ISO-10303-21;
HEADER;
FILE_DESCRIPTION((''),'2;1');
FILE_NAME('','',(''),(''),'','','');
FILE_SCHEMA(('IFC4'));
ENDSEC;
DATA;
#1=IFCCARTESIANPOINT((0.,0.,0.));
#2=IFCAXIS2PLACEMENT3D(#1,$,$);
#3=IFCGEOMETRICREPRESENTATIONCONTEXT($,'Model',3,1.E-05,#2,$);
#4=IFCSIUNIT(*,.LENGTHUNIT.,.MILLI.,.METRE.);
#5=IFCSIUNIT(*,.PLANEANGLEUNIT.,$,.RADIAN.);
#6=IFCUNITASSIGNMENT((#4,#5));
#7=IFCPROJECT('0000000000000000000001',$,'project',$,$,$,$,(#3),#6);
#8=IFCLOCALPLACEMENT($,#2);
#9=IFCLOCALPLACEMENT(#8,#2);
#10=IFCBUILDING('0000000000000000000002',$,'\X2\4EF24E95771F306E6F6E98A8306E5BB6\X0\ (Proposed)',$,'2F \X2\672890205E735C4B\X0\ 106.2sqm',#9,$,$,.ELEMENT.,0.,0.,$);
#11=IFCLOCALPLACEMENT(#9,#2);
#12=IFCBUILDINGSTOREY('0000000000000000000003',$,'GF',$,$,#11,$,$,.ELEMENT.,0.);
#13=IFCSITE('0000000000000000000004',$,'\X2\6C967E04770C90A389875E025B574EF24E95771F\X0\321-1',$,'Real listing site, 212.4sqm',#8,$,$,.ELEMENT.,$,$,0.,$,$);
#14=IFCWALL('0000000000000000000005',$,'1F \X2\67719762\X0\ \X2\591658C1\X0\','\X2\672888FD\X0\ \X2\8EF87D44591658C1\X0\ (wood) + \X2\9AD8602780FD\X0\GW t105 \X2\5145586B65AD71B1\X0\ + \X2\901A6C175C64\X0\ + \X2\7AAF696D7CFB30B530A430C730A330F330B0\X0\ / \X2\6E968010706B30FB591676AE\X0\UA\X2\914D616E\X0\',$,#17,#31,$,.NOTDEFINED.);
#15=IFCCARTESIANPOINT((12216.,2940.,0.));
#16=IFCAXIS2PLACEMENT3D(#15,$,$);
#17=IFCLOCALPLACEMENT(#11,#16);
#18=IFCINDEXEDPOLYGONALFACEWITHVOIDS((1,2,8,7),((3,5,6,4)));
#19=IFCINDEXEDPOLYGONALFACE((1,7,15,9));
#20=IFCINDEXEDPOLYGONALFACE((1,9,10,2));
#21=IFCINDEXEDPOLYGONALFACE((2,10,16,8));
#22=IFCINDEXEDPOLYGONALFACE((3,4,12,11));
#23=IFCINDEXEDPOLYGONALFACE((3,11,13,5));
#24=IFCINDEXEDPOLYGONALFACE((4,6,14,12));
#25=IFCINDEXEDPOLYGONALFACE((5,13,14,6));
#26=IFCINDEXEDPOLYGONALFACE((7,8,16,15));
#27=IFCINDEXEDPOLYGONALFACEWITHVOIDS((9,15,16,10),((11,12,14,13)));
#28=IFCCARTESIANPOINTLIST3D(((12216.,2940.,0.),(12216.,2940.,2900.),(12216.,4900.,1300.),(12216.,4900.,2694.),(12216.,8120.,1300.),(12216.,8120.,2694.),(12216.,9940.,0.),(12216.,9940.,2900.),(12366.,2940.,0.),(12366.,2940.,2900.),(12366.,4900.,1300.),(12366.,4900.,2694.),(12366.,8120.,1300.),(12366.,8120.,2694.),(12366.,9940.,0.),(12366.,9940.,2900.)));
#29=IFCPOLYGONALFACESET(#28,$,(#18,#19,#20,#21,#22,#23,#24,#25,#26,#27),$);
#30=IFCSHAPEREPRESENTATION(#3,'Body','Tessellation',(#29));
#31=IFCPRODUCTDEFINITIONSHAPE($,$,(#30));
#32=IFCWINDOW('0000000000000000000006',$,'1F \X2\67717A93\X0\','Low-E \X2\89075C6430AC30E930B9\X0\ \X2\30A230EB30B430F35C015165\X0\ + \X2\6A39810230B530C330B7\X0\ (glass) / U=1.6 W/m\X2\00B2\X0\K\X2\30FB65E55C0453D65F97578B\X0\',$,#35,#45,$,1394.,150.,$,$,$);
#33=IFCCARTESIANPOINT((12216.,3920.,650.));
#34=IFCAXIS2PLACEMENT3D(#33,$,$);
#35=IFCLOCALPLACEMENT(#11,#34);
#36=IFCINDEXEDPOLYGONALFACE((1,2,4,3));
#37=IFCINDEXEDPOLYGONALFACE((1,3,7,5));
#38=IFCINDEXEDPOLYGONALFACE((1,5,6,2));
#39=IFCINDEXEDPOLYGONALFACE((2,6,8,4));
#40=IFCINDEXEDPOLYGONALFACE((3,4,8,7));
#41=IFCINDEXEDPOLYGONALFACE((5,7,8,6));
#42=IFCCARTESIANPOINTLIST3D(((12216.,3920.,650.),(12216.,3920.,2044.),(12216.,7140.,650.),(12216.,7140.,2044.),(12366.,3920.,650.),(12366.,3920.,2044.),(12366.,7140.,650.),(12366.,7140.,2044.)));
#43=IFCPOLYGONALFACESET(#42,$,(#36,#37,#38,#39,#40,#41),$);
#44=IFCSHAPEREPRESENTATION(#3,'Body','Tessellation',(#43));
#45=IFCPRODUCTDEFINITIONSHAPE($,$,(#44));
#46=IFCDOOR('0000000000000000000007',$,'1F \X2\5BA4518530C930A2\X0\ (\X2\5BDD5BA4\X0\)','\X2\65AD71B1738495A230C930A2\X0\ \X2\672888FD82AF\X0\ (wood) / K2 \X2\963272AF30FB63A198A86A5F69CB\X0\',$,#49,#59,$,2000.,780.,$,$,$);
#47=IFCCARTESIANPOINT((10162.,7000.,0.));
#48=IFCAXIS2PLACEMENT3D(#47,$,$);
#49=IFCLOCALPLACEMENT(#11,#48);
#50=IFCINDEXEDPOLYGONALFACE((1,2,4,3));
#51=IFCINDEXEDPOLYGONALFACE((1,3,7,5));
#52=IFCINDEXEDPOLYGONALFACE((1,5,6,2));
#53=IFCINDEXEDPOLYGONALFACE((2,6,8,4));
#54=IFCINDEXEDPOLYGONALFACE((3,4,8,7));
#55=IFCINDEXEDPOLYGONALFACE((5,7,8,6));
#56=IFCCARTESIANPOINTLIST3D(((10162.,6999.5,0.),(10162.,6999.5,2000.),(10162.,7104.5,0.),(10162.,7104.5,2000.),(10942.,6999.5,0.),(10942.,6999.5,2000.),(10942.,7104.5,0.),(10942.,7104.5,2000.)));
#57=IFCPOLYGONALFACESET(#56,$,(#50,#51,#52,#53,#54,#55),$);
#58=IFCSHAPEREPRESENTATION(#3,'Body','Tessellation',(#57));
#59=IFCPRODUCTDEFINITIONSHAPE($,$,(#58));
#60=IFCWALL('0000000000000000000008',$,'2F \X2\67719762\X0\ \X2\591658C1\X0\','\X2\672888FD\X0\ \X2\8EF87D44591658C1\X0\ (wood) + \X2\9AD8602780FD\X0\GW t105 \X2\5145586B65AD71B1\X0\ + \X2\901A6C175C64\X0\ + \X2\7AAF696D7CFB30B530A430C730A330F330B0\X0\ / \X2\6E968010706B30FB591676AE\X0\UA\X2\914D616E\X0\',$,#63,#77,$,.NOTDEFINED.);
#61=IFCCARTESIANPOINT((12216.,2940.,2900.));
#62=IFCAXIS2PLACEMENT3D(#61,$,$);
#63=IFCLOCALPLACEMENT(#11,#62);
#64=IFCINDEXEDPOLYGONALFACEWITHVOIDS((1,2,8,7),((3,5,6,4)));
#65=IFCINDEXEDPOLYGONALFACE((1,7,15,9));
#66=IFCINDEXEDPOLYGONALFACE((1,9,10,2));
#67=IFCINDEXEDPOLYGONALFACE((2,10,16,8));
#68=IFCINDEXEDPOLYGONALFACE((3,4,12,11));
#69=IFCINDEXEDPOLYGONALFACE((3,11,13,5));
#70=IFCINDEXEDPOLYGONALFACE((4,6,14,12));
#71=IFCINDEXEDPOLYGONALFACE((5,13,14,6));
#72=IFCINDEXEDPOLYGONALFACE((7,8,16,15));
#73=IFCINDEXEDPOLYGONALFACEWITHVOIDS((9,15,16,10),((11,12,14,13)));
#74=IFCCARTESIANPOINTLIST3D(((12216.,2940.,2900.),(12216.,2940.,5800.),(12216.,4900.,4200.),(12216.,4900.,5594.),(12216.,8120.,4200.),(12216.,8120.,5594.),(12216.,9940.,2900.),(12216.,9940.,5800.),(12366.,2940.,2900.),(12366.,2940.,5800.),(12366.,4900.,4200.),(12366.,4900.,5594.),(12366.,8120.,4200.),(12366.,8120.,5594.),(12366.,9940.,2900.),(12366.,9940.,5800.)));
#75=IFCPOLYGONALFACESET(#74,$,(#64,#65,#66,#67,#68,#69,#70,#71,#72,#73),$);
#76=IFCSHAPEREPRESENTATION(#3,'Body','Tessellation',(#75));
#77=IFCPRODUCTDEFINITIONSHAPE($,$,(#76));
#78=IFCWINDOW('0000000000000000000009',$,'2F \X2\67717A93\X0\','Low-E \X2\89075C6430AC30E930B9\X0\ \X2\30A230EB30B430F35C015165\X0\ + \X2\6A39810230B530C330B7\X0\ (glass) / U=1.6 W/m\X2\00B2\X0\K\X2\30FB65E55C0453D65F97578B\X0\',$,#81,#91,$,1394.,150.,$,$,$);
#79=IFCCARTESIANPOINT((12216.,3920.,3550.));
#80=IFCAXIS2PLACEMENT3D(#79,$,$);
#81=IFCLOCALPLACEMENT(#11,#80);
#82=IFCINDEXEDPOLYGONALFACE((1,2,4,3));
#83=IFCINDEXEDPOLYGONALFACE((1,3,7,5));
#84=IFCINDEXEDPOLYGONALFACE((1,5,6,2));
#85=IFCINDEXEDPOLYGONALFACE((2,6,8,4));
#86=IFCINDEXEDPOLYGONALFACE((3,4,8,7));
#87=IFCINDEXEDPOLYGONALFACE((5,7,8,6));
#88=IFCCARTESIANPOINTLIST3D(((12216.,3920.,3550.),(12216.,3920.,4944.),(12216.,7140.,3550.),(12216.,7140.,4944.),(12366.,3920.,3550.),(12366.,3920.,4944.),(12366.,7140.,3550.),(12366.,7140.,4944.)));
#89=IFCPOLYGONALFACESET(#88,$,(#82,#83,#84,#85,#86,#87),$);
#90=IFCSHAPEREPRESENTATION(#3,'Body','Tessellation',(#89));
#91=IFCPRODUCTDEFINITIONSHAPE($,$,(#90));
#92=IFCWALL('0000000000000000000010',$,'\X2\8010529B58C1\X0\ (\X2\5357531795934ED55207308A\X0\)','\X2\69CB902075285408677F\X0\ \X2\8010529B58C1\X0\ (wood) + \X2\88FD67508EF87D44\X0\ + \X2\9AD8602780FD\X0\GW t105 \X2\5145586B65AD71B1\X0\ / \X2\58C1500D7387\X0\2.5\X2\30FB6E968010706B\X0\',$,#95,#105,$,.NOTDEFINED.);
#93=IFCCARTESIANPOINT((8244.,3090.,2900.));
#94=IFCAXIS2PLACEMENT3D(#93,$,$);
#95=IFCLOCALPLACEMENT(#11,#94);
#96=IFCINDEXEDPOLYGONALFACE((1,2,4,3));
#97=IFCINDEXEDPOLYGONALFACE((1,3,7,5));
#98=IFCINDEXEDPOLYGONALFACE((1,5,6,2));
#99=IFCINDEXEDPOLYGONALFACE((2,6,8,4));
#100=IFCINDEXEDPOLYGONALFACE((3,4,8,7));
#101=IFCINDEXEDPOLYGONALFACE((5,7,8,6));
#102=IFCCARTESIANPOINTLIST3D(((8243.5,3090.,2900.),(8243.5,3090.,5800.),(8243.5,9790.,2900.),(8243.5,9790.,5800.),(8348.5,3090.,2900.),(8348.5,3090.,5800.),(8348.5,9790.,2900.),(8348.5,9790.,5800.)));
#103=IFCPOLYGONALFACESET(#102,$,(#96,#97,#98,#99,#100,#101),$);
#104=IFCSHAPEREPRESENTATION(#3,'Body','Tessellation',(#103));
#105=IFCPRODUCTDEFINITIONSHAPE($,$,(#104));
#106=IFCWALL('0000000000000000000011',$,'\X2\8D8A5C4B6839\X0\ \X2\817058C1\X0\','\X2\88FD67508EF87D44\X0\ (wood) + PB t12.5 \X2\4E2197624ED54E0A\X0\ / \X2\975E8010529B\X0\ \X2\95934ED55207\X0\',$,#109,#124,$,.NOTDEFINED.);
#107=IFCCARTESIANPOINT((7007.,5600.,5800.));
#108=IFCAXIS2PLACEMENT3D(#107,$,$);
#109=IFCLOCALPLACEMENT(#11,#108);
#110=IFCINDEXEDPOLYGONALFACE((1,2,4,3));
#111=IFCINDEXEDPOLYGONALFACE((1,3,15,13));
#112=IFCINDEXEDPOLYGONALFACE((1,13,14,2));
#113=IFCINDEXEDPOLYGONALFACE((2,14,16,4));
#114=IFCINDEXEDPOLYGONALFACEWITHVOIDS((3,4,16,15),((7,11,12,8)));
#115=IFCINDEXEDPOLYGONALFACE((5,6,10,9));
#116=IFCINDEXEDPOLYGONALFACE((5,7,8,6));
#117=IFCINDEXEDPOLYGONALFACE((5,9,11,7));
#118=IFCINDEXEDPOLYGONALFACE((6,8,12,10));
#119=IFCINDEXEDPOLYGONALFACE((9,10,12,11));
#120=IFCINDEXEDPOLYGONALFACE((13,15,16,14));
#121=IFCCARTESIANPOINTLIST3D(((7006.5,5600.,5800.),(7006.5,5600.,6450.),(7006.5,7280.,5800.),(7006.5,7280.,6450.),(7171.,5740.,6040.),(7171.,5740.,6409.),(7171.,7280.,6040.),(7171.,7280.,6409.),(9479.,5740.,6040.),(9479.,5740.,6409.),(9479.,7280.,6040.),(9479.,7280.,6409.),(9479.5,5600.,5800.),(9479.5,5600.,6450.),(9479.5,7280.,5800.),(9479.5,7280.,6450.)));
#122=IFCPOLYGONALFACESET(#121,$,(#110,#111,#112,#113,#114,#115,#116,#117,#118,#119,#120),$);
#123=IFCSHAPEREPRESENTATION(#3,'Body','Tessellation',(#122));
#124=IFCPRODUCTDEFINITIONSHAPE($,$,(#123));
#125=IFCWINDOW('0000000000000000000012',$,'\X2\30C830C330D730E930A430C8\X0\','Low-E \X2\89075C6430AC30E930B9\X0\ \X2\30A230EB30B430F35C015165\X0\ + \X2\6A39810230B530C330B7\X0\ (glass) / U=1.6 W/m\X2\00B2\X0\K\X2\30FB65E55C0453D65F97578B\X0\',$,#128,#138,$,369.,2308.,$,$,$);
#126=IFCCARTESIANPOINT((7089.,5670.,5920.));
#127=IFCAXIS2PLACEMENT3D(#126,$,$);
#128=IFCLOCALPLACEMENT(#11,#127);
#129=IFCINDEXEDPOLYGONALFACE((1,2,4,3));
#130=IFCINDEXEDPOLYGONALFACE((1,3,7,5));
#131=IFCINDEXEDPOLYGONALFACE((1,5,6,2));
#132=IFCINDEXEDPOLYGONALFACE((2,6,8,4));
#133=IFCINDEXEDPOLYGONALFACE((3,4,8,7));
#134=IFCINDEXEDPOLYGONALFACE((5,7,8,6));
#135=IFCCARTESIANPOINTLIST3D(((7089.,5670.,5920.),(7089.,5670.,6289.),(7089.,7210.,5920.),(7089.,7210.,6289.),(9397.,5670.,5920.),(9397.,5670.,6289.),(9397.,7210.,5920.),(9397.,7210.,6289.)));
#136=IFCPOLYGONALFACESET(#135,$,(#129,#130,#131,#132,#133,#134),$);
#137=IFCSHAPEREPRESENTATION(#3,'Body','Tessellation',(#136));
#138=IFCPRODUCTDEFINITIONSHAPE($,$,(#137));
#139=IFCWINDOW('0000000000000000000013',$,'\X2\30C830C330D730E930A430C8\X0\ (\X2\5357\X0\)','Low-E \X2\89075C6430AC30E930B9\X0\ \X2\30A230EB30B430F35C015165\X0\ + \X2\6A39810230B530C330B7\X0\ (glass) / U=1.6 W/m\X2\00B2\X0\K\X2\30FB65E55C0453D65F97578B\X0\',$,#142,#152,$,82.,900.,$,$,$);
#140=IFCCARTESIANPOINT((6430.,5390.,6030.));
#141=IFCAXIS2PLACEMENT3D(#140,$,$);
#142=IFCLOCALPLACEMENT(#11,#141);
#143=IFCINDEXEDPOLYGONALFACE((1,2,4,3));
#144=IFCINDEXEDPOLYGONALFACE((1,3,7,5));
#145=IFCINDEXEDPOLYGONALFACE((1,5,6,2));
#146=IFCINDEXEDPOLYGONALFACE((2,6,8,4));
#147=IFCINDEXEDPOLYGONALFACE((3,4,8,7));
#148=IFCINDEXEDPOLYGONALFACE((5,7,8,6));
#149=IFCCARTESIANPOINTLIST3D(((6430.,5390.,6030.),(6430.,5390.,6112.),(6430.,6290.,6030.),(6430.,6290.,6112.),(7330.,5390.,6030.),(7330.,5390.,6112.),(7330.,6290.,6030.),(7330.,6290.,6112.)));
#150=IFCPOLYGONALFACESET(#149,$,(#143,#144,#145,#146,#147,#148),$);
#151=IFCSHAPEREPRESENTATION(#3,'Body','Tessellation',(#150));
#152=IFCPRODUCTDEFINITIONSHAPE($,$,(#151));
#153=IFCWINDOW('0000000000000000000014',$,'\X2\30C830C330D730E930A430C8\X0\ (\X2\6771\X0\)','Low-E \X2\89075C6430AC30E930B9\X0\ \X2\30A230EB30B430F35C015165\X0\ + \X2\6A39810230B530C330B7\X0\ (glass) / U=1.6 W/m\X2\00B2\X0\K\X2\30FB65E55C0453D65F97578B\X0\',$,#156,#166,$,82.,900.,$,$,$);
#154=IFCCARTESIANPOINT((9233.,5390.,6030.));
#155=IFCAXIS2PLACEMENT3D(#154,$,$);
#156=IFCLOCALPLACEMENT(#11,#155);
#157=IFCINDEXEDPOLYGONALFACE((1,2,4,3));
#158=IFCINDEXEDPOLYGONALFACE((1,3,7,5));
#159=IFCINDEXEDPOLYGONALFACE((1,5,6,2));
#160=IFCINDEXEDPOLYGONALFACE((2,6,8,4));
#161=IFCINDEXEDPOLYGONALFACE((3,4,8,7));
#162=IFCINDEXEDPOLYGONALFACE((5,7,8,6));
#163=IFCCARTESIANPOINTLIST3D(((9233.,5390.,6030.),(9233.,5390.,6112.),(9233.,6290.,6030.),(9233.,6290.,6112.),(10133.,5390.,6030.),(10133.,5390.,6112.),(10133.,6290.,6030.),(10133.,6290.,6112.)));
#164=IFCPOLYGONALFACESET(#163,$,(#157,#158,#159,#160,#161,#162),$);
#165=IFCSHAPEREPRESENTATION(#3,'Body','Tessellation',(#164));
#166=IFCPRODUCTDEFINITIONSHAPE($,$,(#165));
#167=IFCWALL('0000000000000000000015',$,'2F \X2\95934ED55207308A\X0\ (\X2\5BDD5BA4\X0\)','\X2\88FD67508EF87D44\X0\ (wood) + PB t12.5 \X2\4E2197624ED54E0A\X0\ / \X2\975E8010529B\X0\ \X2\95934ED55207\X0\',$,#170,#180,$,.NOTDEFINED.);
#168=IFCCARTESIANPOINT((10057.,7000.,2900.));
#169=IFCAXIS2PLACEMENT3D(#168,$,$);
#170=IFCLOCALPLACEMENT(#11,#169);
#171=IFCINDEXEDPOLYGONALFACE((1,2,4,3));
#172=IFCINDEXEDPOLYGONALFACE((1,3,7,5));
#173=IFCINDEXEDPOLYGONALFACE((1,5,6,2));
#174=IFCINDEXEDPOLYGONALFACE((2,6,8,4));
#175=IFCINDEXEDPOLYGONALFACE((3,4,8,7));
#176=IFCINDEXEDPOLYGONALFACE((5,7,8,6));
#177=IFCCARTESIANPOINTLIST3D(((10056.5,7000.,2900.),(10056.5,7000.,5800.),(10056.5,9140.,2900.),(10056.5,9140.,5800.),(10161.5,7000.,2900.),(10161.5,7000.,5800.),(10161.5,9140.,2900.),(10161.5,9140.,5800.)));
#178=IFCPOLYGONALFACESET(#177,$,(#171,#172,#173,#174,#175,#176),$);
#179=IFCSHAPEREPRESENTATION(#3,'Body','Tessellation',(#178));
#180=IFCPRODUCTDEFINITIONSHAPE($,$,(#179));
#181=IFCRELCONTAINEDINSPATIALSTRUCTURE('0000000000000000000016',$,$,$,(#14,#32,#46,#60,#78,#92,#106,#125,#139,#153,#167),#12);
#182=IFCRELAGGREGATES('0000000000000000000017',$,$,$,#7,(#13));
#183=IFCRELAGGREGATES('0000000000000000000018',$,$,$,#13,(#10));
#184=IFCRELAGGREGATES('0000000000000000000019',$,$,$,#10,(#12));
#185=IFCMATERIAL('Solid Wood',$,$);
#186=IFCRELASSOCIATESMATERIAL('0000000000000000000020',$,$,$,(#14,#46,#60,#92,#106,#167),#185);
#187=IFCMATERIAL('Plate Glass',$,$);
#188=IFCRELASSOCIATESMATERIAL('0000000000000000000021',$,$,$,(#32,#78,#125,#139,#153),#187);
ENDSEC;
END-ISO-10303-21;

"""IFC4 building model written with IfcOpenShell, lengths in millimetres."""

from ifc_helpers import new_model, si_unit, frame, frame_2d, origin, place, context, project, spatial, rectangle, extrude, material, element, fill, save


model = new_model("IFC4")

# Units and contexts
model_context = context("Model", 3, precision=1e-05, world=origin())
ifc_project = project(units=[si_unit("LENGTHUNIT", "METRE", prefix="MILLI"), si_unit("PLANEANGLEUNIT", "RADIAN")], contexts=[model_context])

# Site, building, storey
site_placement = place(None, origin())
site = spatial("IfcSite", under=ifc_project, at=site_placement, Name="沖縄県那覇市字仲井真321-1", ObjectType="Real listing site, 212.4sqm", CompositionType="ELEMENT", RefElevation=0.0)
building_placement = place(site_placement, origin())
building = spatial("IfcBuilding", under=site, at=building_placement, Name="仲井真の潮風の家 (Proposed)", ObjectType="2F 木造平屋 106.2sqm", CompositionType="ELEMENT", ElevationOfRefHeight=0.0, ElevationOfTerrain=0.0)
storey_placement = place(building_placement, origin())
storey = spatial("IfcBuildingStorey", under=building, at=storey_placement, Name="GF", CompositionType="ELEMENT", Elevation=0.0)

# Wall, opening, window
ifc_material_1 = material(Name="Solid Wood")
wall_1_placement = place(storey_placement, frame((12216.0, 2940.0, 0.0)))
wall_1 = element("IfcWall", 1, at=wall_1_placement, inside=storey, material=ifc_material_1, Name="1F 東面 外壁", Description="木製 軸組外壁 (wood) + 高性能GW t105 充填断熱 + 通気層 + 窯業系サイディング / 準耐火・外皮UA配慮", PredefinedType="NOTDEFINED", context=model_context, shape_type="SweptSolid", body=[
    extrude(rectangle(XDim=150.0, YDim=7000.0, at=frame_2d((75.0, 3500.0))), frame((12216.0, 2940.0, 0.0)), (0.0, 0.0, 1.0), 2900.0),
])
opening_1_placement = place(storey_placement, frame((12216.0, 3920.0, 650.0)))
opening_1 = element("IfcOpeningElement", 2, at=opening_1_placement, cuts=wall_1, PredefinedType="NOTDEFINED", context=model_context, shape_type="SweptSolid", body=[
    extrude(rectangle(XDim=150.0, YDim=3220.0, at=frame_2d((75.0, 1610.0))), frame((12216.0, 3920.0, 650.0)), (0.0, 0.0, 1.0), 1394.0),
])
ifc_material_2 = material(Name="Plate Glass")
window_1_placement = place(storey_placement, frame((12216.0, 3920.0, 650.0)))
window_1 = element("IfcWindow", 3, at=window_1_placement, inside=storey, material=ifc_material_2, Name="1F 東窓", Description="Low-E 複層ガラス アルゴン封入 + 樹脂サッシ (glass) / U=1.6 W/m²K・日射取得型", OverallHeight=1394.0, OverallWidth=150.0, context=model_context, shape_type="SweptSolid", body=[
    extrude(rectangle(XDim=150.0, YDim=3220.0, at=frame_2d((75.0, 1610.0))), frame((12216.0, 3920.0, 650.0)), (0.0, 0.0, 1.0), 1394.0),
])
fill(opening_1, window_1)

# Door
door_1_placement = place(storey_placement, frame((10162.0, 7000.0, 0.0)))
element("IfcDoor", 4, at=door_1_placement, inside=storey, material=ifc_material_1, Name="1F 室内ドア (寝室)", Description="断熱玄関ドア 木製芯 (wood) / K2 防犯・採風機構", OverallHeight=2000.0, OverallWidth=780.0, context=model_context, shape_type="SweptSolid", body=[
    extrude(rectangle(XDim=780.0, YDim=105.0, at=frame_2d((390.0, 52.0))), frame((10162.0, 7000.0, 0.0)), (0.0, 0.0, 1.0), 2000.0),
])

# Wall, opening, window
wall_2_placement = place(storey_placement, frame((12216.0, 2940.0, 2900.0)))
wall_2 = element("IfcWall", 5, at=wall_2_placement, inside=storey, material=ifc_material_1, Name="2F 東面 外壁", Description="木製 軸組外壁 (wood) + 高性能GW t105 充填断熱 + 通気層 + 窯業系サイディング / 準耐火・外皮UA配慮", PredefinedType="NOTDEFINED", context=model_context, shape_type="SweptSolid", body=[
    extrude(rectangle(XDim=150.0, YDim=7000.0, at=frame_2d((75.0, 3500.0))), frame((12216.0, 2940.0, 2900.0)), (0.0, 0.0, 1.0), 2900.0),
])
opening_2_placement = place(storey_placement, frame((12216.0, 3920.0, 3550.0)))
opening_2 = element("IfcOpeningElement", 6, at=opening_2_placement, cuts=wall_2, PredefinedType="NOTDEFINED", context=model_context, shape_type="SweptSolid", body=[
    extrude(rectangle(XDim=150.0, YDim=3220.0, at=frame_2d((75.0, 1610.0))), frame((12216.0, 3920.0, 3550.0)), (0.0, 0.0, 1.0), 1394.0),
])
window_2_placement = place(storey_placement, frame((12216.0, 3920.0, 3550.0)))
window_2 = element("IfcWindow", 7, at=window_2_placement, inside=storey, material=ifc_material_2, Name="2F 東窓", Description="Low-E 複層ガラス アルゴン封入 + 樹脂サッシ (glass) / U=1.6 W/m²K・日射取得型", OverallHeight=1394.0, OverallWidth=150.0, context=model_context, shape_type="SweptSolid", body=[
    extrude(rectangle(XDim=150.0, YDim=3220.0, at=frame_2d((75.0, 1610.0))), frame((12216.0, 3920.0, 3550.0)), (0.0, 0.0, 1.0), 1394.0),
])
fill(opening_2, window_2)

# Wall
wall_3_placement = place(storey_placement, frame((8244.0, 3090.0, 2900.0)))
element("IfcWall", 8, at=wall_3_placement, inside=storey, material=ifc_material_1, Name="耐力壁 (南北間仕切り)", Description="構造用合板 耐力壁 (wood) + 製材軸組 + 高性能GW t105 充填断熱 / 壁倍率2.5・準耐火", PredefinedType="NOTDEFINED", context=model_context, shape_type="SweptSolid", body=[
    extrude(rectangle(XDim=105.0, YDim=6700.0, at=frame_2d((52.0, 3350.0))), frame((8244.0, 3090.0, 2900.0)), (0.0, 0.0, 1.0), 2900.0),
])

# Wall, openings, windows
wall_4_placement = place(storey_placement, frame((7007.0, 5600.0, 5800.0)))
wall_4 = element("IfcWall", 9, at=wall_4_placement, inside=storey, material=ifc_material_1, Name="越屋根 腰壁", Description="製材軸組 (wood) + PB t12.5 両面仕上 / 非耐力 間仕切", PredefinedType="NOTDEFINED", context=model_context, shape_type="SweptSolid", body=[
    extrude(rectangle(XDim=2473.0, YDim=1680.0, at=frame_2d((1236.0, 840.0))), frame((7007.0, 5600.0, 5800.0)), (0.0, 0.0, 1.0), 650.0),
])
opening_3_placement = place(storey_placement, frame((7089.0, 5670.0, 5920.0)))
opening_3 = element("IfcOpeningElement", 10, at=opening_3_placement, cuts=wall_4, PredefinedType="NOTDEFINED", context=model_context, shape_type="SweptSolid", body=[
    extrude(rectangle(XDim=2308.0, YDim=1540.0, at=frame_2d((1154.0, 770.0))), frame((7089.0, 5670.0, 5920.0)), (0.0, 0.0, 1.0), 369.0),
])
opening_4_placement = place(storey_placement, frame((6430.0, 5390.0, 6030.0)))
opening_4 = element("IfcOpeningElement", 11, at=opening_4_placement, cuts=wall_4, PredefinedType="NOTDEFINED", context=model_context, shape_type="SweptSolid", body=[
    extrude(rectangle(XDim=900.0, YDim=900.0, at=frame_2d((450.0, 450.0))), frame((6430.0, 5390.0, 6030.0)), (0.0, 0.0, 1.0), 82.0),
])
opening_5_placement = place(storey_placement, frame((9233.0, 5390.0, 6030.0)))
opening_5 = element("IfcOpeningElement", 12, at=opening_5_placement, cuts=wall_4, PredefinedType="NOTDEFINED", context=model_context, shape_type="SweptSolid", body=[
    extrude(rectangle(XDim=900.0, YDim=900.0, at=frame_2d((450.0, 450.0))), frame((9233.0, 5390.0, 6030.0)), (0.0, 0.0, 1.0), 82.0),
])
window_3_placement = place(storey_placement, frame((7089.0, 5670.0, 5920.0)))
window_3 = element("IfcWindow", 13, at=window_3_placement, inside=storey, material=ifc_material_2, Name="トップライト", Description="Low-E 複層ガラス アルゴン封入 + 樹脂サッシ (glass) / U=1.6 W/m²K・日射取得型", OverallHeight=369.0, OverallWidth=2308.0, context=model_context, shape_type="SweptSolid", body=[
    extrude(rectangle(XDim=2308.0, YDim=1540.0, at=frame_2d((1154.0, 770.0))), frame((7089.0, 5670.0, 5920.0)), (0.0, 0.0, 1.0), 369.0),
])
fill(opening_3, window_3)
window_4_placement = place(storey_placement, frame((6430.0, 5390.0, 6030.0)))
window_4 = element("IfcWindow", 14, at=window_4_placement, inside=storey, material=ifc_material_2, Name="トップライト (南)", Description="Low-E 複層ガラス アルゴン封入 + 樹脂サッシ (glass) / U=1.6 W/m²K・日射取得型", OverallHeight=82.0, OverallWidth=900.0, context=model_context, shape_type="SweptSolid", body=[
    extrude(rectangle(XDim=900.0, YDim=900.0, at=frame_2d((450.0, 450.0))), frame((6430.0, 5390.0, 6030.0)), (0.0, 0.0, 1.0), 82.0),
])
fill(opening_4, window_4)
window_5_placement = place(storey_placement, frame((9233.0, 5390.0, 6030.0)))
window_5 = element("IfcWindow", 15, at=window_5_placement, inside=storey, material=ifc_material_2, Name="トップライト (東)", Description="Low-E 複層ガラス アルゴン封入 + 樹脂サッシ (glass) / U=1.6 W/m²K・日射取得型", OverallHeight=82.0, OverallWidth=900.0, context=model_context, shape_type="SweptSolid", body=[
    extrude(rectangle(XDim=900.0, YDim=900.0, at=frame_2d((450.0, 450.0))), frame((9233.0, 5390.0, 6030.0)), (0.0, 0.0, 1.0), 82.0),
])
fill(opening_5, window_5)

# Wall
wall_5_placement = place(storey_placement, frame((10057.0, 7000.0, 2900.0)))
element("IfcWall", 16, at=wall_5_placement, inside=storey, material=ifc_material_1, Name="2F 間仕切り (寝室)", Description="製材軸組 (wood) + PB t12.5 両面仕上 / 非耐力 間仕切", PredefinedType="NOTDEFINED", context=model_context, shape_type="SweptSolid", body=[
    extrude(rectangle(XDim=105.0, YDim=2140.0, at=frame_2d((52.0, 1070.0))), frame((10057.0, 7000.0, 2900.0)), (0.0, 0.0, 1.0), 2900.0),
])

save(model, "model.ifc")
